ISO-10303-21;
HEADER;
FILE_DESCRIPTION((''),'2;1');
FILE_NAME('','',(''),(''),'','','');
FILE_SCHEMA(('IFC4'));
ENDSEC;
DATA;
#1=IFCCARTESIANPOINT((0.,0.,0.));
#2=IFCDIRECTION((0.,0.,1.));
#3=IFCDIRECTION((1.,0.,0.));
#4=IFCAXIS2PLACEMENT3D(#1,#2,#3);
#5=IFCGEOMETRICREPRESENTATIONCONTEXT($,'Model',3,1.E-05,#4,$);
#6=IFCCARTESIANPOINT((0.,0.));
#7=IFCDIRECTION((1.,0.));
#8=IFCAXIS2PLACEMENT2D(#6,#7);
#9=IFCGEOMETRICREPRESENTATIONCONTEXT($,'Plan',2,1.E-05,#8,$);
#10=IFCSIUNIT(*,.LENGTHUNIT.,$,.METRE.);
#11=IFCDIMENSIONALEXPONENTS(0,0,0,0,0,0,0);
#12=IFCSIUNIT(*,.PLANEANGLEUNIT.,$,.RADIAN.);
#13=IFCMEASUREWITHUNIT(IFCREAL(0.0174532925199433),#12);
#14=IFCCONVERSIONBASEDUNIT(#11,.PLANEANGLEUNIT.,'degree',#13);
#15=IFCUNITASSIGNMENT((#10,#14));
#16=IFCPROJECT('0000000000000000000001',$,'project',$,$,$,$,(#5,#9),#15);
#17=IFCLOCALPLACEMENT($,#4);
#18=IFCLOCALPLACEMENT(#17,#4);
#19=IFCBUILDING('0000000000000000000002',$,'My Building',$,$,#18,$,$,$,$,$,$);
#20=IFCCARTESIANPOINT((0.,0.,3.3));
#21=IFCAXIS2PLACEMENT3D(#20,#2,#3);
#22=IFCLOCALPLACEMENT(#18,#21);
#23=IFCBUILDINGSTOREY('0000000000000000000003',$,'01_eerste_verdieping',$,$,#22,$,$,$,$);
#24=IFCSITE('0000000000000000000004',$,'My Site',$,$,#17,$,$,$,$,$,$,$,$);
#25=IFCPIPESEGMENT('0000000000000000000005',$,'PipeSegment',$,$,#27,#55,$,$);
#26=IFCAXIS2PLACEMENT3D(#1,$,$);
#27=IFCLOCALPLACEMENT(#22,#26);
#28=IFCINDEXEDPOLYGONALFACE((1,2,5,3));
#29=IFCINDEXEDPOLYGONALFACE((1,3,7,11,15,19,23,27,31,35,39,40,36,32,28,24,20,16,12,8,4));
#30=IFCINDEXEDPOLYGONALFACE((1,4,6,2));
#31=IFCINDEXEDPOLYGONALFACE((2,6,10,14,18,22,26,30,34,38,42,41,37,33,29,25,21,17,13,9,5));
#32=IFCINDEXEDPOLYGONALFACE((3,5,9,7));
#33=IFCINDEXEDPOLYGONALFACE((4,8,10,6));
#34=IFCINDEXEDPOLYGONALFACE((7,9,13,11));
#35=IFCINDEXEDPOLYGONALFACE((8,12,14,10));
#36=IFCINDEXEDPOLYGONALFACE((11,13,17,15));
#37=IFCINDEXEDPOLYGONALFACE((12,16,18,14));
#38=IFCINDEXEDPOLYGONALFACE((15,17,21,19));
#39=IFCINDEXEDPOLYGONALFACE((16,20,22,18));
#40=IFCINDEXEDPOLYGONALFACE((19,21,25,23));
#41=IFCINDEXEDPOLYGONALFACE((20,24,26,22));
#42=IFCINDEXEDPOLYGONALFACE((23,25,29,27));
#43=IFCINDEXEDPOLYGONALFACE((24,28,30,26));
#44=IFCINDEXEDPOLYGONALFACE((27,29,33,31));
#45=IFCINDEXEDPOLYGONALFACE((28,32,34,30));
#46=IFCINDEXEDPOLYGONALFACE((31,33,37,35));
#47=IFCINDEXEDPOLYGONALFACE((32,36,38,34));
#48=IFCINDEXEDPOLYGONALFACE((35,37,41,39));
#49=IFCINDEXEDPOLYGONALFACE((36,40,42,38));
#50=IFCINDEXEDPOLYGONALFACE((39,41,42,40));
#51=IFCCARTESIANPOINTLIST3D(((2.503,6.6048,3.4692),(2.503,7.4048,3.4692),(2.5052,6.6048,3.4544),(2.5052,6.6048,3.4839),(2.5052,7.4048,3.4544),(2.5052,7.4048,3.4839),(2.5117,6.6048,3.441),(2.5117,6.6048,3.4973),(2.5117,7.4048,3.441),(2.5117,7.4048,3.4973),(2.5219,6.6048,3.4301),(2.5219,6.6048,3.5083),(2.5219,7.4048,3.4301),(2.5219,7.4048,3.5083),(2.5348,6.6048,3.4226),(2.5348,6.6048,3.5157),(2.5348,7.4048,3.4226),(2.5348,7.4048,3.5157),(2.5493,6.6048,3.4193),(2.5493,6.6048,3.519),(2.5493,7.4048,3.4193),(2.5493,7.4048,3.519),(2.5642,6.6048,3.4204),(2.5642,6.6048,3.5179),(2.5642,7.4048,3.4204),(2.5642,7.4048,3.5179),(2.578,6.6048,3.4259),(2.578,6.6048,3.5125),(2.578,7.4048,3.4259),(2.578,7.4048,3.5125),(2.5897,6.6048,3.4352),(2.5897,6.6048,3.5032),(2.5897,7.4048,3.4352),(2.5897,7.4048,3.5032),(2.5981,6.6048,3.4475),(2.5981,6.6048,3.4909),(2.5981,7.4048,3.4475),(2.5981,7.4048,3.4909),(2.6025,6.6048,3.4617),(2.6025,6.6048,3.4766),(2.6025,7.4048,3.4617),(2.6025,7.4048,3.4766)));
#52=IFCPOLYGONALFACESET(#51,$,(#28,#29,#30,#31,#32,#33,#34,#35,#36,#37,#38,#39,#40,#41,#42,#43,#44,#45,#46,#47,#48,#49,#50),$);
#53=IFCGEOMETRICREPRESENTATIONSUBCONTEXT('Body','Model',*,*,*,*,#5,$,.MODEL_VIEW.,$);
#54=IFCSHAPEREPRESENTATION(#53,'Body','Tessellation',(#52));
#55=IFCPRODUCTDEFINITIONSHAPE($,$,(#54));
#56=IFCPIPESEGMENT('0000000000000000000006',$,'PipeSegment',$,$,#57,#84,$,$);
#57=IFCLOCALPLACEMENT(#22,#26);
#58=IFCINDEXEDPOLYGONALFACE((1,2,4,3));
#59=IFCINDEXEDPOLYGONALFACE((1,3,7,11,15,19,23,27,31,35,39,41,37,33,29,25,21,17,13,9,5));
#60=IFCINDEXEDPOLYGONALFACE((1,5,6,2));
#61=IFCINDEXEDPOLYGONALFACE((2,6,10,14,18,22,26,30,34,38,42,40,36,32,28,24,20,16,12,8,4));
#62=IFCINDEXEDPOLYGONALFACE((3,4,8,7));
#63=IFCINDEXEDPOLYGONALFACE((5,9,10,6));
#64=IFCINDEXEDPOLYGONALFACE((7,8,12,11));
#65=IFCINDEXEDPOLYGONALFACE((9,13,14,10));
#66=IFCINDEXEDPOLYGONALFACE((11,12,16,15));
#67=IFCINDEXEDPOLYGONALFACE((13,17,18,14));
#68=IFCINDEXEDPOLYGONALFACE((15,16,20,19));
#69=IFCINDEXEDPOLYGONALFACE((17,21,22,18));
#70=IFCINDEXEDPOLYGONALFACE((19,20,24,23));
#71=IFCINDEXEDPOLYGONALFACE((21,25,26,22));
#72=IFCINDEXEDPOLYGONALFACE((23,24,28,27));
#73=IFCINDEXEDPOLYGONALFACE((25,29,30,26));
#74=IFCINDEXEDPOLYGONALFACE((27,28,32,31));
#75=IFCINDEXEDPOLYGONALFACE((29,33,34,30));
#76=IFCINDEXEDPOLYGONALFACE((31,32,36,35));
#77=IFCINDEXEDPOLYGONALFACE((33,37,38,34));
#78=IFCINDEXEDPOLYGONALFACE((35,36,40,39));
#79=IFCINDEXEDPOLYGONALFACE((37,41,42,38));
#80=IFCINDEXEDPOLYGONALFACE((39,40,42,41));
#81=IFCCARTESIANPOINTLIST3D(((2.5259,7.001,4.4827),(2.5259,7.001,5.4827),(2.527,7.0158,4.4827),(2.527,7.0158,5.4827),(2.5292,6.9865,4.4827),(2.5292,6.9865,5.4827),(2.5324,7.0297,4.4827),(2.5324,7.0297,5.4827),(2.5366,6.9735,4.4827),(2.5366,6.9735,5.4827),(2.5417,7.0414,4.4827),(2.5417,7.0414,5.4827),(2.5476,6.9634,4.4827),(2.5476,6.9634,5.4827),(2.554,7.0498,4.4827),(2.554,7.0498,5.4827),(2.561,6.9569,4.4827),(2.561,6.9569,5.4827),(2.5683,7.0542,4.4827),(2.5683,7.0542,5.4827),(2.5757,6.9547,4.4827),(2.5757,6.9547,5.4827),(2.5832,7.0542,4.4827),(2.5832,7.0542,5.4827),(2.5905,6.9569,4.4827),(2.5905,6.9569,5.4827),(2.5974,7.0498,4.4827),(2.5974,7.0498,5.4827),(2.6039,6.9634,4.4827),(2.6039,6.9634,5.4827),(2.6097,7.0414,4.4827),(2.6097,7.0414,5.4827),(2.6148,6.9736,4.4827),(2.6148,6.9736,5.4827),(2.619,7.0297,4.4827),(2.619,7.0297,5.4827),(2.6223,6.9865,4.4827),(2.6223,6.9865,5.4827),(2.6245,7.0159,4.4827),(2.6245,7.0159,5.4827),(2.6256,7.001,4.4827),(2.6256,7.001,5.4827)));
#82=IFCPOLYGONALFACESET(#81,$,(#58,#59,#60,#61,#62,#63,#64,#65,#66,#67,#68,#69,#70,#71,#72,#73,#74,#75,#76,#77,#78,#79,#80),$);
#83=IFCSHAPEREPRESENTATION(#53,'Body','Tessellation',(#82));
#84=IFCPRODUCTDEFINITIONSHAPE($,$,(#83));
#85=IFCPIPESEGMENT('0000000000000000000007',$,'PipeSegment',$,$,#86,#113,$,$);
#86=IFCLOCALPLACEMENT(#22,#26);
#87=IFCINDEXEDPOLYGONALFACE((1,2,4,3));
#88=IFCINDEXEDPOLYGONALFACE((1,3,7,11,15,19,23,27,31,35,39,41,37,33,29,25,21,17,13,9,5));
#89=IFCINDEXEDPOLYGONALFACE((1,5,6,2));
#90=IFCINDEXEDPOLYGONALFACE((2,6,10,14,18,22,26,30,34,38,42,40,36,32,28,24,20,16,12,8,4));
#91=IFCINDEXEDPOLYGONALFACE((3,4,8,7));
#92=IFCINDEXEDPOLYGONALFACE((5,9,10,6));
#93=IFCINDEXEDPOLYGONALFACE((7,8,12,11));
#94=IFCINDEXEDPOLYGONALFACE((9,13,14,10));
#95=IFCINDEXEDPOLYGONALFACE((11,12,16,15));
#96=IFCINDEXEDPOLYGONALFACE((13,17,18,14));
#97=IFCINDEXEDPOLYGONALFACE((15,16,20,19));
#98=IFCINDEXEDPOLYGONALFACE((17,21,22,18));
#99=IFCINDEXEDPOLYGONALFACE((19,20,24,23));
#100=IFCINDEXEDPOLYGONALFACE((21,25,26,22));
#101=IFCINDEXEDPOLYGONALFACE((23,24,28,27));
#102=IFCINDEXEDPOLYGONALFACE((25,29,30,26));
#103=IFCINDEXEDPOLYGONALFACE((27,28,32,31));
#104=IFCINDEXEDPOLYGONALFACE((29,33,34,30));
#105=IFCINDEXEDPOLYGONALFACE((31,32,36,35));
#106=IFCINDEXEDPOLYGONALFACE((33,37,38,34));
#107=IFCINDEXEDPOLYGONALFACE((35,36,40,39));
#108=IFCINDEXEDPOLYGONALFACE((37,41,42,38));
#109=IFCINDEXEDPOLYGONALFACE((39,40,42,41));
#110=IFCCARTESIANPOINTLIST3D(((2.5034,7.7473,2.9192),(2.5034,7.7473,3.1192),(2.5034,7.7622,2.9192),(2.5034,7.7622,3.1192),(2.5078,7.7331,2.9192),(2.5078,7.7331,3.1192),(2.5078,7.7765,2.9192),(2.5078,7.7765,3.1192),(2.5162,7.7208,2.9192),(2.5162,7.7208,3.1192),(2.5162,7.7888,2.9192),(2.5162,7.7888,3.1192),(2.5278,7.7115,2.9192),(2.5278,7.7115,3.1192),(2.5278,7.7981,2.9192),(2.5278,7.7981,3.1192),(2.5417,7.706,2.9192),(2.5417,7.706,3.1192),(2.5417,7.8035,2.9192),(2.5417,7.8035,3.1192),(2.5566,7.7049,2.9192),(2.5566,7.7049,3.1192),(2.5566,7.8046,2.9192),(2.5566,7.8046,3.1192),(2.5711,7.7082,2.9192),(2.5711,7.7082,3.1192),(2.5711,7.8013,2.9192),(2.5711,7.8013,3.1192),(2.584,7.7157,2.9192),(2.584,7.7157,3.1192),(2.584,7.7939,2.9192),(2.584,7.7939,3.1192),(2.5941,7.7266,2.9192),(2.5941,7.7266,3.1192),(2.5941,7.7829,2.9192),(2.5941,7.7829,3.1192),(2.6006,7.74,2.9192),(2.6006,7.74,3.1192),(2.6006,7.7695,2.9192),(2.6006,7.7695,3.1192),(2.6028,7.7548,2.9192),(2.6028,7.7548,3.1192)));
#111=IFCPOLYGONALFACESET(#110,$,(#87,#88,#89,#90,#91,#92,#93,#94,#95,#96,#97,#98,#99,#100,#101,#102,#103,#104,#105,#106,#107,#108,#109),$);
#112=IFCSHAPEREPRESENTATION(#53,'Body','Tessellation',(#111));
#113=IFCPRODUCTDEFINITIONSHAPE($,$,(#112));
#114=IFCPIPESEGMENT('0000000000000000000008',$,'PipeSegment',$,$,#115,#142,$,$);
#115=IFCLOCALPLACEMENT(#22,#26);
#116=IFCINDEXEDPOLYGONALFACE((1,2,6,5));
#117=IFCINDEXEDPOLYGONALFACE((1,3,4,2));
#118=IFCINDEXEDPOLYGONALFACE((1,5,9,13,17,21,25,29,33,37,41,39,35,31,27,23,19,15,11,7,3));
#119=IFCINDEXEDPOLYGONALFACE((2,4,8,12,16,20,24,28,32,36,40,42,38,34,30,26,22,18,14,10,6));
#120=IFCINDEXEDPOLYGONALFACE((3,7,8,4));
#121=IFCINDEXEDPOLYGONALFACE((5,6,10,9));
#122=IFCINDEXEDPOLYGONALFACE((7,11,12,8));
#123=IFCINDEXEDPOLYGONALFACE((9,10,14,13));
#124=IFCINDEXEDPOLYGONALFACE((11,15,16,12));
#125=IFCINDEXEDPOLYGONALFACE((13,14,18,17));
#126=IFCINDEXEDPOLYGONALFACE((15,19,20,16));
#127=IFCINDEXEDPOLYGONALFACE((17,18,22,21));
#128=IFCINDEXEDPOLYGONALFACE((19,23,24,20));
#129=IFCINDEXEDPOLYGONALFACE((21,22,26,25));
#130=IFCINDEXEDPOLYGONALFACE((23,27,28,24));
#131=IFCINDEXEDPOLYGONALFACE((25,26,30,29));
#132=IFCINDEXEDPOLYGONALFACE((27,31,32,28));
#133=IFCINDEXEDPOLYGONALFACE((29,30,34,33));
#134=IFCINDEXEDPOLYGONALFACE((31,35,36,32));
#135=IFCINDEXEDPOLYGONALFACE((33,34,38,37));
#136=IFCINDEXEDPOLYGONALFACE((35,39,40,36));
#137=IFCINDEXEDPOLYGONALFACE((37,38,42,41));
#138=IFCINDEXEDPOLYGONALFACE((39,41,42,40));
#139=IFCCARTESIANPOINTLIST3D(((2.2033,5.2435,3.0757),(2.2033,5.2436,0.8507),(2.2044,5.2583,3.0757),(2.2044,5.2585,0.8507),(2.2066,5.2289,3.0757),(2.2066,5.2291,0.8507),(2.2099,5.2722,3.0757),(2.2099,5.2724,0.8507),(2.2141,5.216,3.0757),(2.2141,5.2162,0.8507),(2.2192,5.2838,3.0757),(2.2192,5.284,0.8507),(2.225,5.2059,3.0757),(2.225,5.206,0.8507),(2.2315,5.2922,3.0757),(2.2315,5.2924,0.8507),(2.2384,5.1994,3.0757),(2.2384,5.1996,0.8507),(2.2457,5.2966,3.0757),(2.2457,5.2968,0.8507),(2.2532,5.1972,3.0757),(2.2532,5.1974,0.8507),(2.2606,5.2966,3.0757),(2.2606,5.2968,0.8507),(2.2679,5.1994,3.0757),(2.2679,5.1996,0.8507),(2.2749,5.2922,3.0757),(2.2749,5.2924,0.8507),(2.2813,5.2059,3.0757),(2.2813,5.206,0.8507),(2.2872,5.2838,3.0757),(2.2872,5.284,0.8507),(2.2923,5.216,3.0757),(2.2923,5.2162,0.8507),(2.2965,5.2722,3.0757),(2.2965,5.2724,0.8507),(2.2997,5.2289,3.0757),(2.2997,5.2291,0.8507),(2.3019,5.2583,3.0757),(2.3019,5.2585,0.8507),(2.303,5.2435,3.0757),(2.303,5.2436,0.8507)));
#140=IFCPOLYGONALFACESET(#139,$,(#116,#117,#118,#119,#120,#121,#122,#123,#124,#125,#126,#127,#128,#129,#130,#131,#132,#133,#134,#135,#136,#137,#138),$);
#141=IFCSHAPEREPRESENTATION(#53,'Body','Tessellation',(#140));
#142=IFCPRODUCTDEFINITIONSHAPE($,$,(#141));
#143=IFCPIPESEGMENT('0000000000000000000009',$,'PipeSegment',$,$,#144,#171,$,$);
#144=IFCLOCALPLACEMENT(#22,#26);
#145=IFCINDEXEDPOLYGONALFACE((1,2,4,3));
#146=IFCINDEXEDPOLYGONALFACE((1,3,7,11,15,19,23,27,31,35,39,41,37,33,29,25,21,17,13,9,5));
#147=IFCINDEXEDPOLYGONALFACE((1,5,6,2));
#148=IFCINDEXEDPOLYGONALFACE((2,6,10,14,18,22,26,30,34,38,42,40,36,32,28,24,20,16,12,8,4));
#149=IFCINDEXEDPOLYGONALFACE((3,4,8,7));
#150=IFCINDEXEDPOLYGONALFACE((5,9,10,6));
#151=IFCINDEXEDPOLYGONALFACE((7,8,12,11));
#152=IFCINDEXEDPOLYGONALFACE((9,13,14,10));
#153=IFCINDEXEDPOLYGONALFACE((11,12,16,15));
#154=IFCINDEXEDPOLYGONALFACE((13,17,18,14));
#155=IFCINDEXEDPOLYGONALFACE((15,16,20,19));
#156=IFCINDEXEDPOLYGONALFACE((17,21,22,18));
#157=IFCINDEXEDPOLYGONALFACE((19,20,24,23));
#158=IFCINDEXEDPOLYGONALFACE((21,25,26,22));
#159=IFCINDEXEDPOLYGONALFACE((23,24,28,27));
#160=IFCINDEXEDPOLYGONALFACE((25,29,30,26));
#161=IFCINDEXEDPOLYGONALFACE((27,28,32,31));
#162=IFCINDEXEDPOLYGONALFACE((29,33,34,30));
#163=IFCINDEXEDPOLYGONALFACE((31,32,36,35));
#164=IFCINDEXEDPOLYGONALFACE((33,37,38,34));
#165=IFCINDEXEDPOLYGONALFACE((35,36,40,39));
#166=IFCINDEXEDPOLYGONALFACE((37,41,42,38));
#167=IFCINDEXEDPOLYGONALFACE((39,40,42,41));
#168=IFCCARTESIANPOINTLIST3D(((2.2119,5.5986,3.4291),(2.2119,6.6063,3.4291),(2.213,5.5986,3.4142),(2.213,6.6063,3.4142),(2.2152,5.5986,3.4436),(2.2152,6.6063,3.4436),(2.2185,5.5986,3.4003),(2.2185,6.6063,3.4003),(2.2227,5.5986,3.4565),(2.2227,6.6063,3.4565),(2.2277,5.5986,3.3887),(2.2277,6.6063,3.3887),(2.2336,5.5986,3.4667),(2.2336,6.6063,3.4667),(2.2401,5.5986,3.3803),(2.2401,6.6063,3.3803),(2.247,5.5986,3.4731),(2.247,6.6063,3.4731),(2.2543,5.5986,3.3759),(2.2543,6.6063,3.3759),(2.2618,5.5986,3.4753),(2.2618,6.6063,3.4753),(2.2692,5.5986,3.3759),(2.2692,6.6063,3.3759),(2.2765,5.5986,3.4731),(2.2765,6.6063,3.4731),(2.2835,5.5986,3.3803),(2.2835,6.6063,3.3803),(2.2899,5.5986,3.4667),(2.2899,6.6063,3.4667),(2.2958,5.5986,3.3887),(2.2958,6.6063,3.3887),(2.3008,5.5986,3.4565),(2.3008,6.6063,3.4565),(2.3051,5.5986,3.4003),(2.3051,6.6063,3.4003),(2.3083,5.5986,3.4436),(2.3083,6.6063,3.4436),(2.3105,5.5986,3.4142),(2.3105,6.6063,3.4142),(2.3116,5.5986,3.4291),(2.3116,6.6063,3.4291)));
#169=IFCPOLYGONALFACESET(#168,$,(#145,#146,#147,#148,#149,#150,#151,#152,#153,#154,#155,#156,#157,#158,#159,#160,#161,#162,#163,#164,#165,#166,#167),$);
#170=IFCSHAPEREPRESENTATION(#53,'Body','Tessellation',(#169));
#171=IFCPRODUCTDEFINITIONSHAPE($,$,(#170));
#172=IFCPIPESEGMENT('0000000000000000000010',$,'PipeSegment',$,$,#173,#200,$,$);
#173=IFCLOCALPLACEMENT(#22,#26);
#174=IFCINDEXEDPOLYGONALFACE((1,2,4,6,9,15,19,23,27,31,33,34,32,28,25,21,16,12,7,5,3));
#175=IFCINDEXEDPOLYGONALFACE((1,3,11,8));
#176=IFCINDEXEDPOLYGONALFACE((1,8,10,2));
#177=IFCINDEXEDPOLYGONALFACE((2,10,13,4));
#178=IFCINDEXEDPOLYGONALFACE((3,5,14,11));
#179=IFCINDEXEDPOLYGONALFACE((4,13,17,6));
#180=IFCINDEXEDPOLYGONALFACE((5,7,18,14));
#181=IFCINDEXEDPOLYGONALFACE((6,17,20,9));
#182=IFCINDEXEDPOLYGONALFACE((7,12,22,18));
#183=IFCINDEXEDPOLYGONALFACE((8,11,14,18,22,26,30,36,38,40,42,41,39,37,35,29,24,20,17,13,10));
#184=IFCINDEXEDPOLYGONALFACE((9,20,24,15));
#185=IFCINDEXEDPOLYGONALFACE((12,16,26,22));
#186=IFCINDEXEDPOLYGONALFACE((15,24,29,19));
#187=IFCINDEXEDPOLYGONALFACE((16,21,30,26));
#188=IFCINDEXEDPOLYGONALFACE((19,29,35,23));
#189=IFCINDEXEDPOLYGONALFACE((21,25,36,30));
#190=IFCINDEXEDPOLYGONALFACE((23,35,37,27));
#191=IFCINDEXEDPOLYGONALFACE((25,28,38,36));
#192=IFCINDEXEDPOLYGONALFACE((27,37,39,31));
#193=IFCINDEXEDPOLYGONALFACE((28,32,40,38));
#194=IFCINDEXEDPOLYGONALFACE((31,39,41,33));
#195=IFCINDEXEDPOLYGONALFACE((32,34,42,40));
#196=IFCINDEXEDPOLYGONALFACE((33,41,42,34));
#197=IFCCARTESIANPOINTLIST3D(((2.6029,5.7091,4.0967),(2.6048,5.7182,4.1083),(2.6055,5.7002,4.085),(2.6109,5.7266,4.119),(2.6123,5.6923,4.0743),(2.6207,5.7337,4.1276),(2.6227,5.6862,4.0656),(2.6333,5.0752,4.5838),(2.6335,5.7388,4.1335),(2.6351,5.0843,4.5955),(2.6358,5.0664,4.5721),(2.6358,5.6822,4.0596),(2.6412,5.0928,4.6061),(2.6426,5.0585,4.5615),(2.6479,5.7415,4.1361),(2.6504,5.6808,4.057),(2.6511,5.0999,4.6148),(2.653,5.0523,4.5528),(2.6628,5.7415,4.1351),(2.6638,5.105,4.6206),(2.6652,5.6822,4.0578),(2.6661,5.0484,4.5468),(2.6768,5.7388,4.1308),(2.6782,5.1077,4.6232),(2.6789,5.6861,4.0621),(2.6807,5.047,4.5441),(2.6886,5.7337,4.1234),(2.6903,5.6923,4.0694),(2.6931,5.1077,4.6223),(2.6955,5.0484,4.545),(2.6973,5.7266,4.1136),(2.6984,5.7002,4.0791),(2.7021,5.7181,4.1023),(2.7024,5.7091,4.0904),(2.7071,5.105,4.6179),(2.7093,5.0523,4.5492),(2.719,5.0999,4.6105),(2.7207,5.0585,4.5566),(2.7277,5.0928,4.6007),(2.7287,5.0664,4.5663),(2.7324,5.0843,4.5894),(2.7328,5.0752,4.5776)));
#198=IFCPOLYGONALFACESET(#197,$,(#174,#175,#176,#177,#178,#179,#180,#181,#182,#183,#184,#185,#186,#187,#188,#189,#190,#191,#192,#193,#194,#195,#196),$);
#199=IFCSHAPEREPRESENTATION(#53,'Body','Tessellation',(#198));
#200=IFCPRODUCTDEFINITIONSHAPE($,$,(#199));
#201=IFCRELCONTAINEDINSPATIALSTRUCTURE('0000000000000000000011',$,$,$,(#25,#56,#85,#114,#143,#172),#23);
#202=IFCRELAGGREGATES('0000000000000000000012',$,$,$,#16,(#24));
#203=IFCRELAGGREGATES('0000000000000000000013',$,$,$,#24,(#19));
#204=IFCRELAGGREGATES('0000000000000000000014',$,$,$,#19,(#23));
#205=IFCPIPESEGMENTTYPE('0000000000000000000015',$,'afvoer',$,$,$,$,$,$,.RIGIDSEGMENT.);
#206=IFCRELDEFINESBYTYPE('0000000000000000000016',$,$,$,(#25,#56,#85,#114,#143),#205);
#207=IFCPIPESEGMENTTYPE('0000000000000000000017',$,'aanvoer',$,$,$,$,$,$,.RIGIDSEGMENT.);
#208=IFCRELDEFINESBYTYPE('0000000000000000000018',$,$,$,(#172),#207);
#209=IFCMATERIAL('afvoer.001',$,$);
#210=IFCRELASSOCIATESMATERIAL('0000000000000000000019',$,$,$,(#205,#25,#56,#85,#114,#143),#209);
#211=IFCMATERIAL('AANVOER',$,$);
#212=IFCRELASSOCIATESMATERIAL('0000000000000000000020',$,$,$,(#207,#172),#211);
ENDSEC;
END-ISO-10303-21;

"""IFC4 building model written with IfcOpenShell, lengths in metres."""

from ifc_helpers import new_model, entity, si_unit, converted_unit, frame, origin_with_axes, origin_2d_with_axis, place, context, subcontext, project, spatial, circle, extrude, material, material_profile, profile_set, profile_usage, type_object, element, save


model = new_model("IFC4")

# Units and contexts
model_context = context("Model", 3, precision=1e-05, world=origin_with_axes())
plan_context = context("Plan", 2, precision=1e-05, world=origin_2d_with_axis())
body_context_1 = subcontext(model_context, "Body", "Model", "MODEL_VIEW")
ifc_project = project(units=[si_unit("LENGTHUNIT", "METRE"), converted_unit("PLANEANGLEUNIT", "degree", entity("IfcReal", 0.0174532925199433), si_unit("PLANEANGLEUNIT", "RADIAN"), dimensions=[0, 0, 0, 0, 0, 0, 0])], contexts=[model_context, plan_context])

# Site, building, storey
site_placement = place(None, origin_with_axes())
site = spatial("IfcSite", under=ifc_project, at=site_placement, Name="My Site")
building_placement = place(site_placement, origin_with_axes())
building = spatial("IfcBuilding", under=site, at=building_placement, Name="My Building")
storey_placement = place(building_placement, frame((0.0, 0.0, 3.3), z_axis=(0.0, 0.0, 1.0), x_axis=(1.0, 0.0, 0.0)))
storey = spatial("IfcBuildingStorey", under=building, at=storey_placement, Name="01_eerste_verdieping")

# Pipe segments
ifc_material_1 = material(Name="afvoer.001")
ifc_material_profile_1 = material_profile(ifc_material_1, circle(Radius=0.05))
ifc_profile_set_1 = profile_set([ifc_material_profile_1])
ifc_profile_usage_1 = profile_usage(ifc_profile_set_1, cardinal=5)
pipe_segment_type_1 = type_object("IfcPipeSegmentType", Name="afvoer", PredefinedType="RIGIDSEGMENT", material=ifc_profile_set_1)
pipe_segment_1_placement = place(storey_placement, frame((2.553, 6.6048, 3.4692), z_axis=(0.0, 1.0, 0.0), x_axis=(-1.0, 0.0, 0.0)))
element("IfcPipeSegment", 1, at=pipe_segment_1_placement, inside=storey, type_object=pipe_segment_type_1, material=ifc_profile_usage_1, Name="PipeSegment", context=body_context_1, shape_type="SweptSolid", body=[
    extrude(circle(Radius=0.05), origin_with_axes(), (0.0, 0.0, 1.0), 0.8),
])
ifc_profile_usage_2 = profile_usage(ifc_profile_set_1, cardinal=5)
pipe_segment_2_placement = place(storey_placement, frame((2.5757, 7.0047, 5.4827), z_axis=(0.0, 0.0, -1.0), x_axis=(0.000074, -1.0, 0.0)))
element("IfcPipeSegment", 2, at=pipe_segment_2_placement, inside=storey, type_object=pipe_segment_type_1, material=ifc_profile_usage_2, Name="PipeSegment", context=body_context_1, shape_type="SweptSolid", body=[
    extrude(circle(Radius=0.05), origin_with_axes(), (0.0, 0.0, 1.0), 1.0),
])
ifc_profile_usage_3 = profile_usage(ifc_profile_set_1, cardinal=5)
pipe_segment_3_placement = place(storey_placement, frame((2.5528, 7.7548, 3.1192), z_axis=(0.0, 0.0, -1.0), x_axis=(1.0, 0.0, 0.0)))
element("IfcPipeSegment", 3, at=pipe_segment_3_placement, inside=storey, type_object=pipe_segment_type_1, material=ifc_profile_usage_3, Name="PipeSegment", context=body_context_1, shape_type="SweptSolid", body=[
    extrude(circle(Radius=0.05), origin_with_axes(), (0.0, 0.0, 1.0), 0.2),
])
ifc_profile_usage_4 = profile_usage(ifc_profile_set_1, cardinal=5)
pipe_segment_4_placement = place(storey_placement, frame((2.2532, 5.2474, 0.8507), z_axis=(0.0, -0.000073, 1.0), x_axis=(0.0, -1.0, -0.000073)))
element("IfcPipeSegment", 4, at=pipe_segment_4_placement, inside=storey, type_object=pipe_segment_type_1, material=ifc_profile_usage_4, Name="PipeSegment", context=body_context_1, shape_type="SweptSolid", body=[
    extrude(circle(Radius=0.05), origin_with_axes(), (0.0, 0.0, 1.0), 2.225),
])
ifc_profile_usage_5 = profile_usage(ifc_profile_set_1, cardinal=5)
pipe_segment_5_placement = place(storey_placement, frame((2.2618, 5.5986, 3.4253), z_axis=(0.0, 1.0, 0.0), x_axis=(0.0, 0.0, 1.0)))
element("IfcPipeSegment", 5, at=pipe_segment_5_placement, inside=storey, type_object=pipe_segment_type_1, material=ifc_profile_usage_5, Name="PipeSegment", context=body_context_1, shape_type="SweptSolid", body=[
    extrude(circle(Radius=0.05), origin_with_axes(), (0.0, 0.0, 1.0), 1.0077),
])
ifc_material_2 = material(Name="AANVOER")
ifc_material_profile_2 = material_profile(ifc_material_2, circle(Radius=0.05))
ifc_profile_set_2 = profile_set([ifc_material_profile_2])
ifc_profile_usage_6 = profile_usage(ifc_profile_set_2)
pipe_segment_type_2 = type_object("IfcPipeSegmentType", Name="aanvoer", PredefinedType="RIGIDSEGMENT", material=ifc_profile_set_2)
pipe_segment_6_placement = place(storey_placement, frame((2.6832, 5.0775, 4.5837), z_axis=(-0.037914, 0.7923, -0.608953), x_axis=(-0.998967, -0.045327, 0.003222)))
element("IfcPipeSegment", 6, at=pipe_segment_6_placement, inside=storey, type_object=pipe_segment_type_2, material=ifc_profile_usage_6, Name="PipeSegment", context=body_context_1, shape_type="SweptSolid", body=[
    extrude(circle(Radius=0.05), origin_with_axes(), (0.0, 0.0, 1.0), 0.8),
])

save(model, "model.ifc")
